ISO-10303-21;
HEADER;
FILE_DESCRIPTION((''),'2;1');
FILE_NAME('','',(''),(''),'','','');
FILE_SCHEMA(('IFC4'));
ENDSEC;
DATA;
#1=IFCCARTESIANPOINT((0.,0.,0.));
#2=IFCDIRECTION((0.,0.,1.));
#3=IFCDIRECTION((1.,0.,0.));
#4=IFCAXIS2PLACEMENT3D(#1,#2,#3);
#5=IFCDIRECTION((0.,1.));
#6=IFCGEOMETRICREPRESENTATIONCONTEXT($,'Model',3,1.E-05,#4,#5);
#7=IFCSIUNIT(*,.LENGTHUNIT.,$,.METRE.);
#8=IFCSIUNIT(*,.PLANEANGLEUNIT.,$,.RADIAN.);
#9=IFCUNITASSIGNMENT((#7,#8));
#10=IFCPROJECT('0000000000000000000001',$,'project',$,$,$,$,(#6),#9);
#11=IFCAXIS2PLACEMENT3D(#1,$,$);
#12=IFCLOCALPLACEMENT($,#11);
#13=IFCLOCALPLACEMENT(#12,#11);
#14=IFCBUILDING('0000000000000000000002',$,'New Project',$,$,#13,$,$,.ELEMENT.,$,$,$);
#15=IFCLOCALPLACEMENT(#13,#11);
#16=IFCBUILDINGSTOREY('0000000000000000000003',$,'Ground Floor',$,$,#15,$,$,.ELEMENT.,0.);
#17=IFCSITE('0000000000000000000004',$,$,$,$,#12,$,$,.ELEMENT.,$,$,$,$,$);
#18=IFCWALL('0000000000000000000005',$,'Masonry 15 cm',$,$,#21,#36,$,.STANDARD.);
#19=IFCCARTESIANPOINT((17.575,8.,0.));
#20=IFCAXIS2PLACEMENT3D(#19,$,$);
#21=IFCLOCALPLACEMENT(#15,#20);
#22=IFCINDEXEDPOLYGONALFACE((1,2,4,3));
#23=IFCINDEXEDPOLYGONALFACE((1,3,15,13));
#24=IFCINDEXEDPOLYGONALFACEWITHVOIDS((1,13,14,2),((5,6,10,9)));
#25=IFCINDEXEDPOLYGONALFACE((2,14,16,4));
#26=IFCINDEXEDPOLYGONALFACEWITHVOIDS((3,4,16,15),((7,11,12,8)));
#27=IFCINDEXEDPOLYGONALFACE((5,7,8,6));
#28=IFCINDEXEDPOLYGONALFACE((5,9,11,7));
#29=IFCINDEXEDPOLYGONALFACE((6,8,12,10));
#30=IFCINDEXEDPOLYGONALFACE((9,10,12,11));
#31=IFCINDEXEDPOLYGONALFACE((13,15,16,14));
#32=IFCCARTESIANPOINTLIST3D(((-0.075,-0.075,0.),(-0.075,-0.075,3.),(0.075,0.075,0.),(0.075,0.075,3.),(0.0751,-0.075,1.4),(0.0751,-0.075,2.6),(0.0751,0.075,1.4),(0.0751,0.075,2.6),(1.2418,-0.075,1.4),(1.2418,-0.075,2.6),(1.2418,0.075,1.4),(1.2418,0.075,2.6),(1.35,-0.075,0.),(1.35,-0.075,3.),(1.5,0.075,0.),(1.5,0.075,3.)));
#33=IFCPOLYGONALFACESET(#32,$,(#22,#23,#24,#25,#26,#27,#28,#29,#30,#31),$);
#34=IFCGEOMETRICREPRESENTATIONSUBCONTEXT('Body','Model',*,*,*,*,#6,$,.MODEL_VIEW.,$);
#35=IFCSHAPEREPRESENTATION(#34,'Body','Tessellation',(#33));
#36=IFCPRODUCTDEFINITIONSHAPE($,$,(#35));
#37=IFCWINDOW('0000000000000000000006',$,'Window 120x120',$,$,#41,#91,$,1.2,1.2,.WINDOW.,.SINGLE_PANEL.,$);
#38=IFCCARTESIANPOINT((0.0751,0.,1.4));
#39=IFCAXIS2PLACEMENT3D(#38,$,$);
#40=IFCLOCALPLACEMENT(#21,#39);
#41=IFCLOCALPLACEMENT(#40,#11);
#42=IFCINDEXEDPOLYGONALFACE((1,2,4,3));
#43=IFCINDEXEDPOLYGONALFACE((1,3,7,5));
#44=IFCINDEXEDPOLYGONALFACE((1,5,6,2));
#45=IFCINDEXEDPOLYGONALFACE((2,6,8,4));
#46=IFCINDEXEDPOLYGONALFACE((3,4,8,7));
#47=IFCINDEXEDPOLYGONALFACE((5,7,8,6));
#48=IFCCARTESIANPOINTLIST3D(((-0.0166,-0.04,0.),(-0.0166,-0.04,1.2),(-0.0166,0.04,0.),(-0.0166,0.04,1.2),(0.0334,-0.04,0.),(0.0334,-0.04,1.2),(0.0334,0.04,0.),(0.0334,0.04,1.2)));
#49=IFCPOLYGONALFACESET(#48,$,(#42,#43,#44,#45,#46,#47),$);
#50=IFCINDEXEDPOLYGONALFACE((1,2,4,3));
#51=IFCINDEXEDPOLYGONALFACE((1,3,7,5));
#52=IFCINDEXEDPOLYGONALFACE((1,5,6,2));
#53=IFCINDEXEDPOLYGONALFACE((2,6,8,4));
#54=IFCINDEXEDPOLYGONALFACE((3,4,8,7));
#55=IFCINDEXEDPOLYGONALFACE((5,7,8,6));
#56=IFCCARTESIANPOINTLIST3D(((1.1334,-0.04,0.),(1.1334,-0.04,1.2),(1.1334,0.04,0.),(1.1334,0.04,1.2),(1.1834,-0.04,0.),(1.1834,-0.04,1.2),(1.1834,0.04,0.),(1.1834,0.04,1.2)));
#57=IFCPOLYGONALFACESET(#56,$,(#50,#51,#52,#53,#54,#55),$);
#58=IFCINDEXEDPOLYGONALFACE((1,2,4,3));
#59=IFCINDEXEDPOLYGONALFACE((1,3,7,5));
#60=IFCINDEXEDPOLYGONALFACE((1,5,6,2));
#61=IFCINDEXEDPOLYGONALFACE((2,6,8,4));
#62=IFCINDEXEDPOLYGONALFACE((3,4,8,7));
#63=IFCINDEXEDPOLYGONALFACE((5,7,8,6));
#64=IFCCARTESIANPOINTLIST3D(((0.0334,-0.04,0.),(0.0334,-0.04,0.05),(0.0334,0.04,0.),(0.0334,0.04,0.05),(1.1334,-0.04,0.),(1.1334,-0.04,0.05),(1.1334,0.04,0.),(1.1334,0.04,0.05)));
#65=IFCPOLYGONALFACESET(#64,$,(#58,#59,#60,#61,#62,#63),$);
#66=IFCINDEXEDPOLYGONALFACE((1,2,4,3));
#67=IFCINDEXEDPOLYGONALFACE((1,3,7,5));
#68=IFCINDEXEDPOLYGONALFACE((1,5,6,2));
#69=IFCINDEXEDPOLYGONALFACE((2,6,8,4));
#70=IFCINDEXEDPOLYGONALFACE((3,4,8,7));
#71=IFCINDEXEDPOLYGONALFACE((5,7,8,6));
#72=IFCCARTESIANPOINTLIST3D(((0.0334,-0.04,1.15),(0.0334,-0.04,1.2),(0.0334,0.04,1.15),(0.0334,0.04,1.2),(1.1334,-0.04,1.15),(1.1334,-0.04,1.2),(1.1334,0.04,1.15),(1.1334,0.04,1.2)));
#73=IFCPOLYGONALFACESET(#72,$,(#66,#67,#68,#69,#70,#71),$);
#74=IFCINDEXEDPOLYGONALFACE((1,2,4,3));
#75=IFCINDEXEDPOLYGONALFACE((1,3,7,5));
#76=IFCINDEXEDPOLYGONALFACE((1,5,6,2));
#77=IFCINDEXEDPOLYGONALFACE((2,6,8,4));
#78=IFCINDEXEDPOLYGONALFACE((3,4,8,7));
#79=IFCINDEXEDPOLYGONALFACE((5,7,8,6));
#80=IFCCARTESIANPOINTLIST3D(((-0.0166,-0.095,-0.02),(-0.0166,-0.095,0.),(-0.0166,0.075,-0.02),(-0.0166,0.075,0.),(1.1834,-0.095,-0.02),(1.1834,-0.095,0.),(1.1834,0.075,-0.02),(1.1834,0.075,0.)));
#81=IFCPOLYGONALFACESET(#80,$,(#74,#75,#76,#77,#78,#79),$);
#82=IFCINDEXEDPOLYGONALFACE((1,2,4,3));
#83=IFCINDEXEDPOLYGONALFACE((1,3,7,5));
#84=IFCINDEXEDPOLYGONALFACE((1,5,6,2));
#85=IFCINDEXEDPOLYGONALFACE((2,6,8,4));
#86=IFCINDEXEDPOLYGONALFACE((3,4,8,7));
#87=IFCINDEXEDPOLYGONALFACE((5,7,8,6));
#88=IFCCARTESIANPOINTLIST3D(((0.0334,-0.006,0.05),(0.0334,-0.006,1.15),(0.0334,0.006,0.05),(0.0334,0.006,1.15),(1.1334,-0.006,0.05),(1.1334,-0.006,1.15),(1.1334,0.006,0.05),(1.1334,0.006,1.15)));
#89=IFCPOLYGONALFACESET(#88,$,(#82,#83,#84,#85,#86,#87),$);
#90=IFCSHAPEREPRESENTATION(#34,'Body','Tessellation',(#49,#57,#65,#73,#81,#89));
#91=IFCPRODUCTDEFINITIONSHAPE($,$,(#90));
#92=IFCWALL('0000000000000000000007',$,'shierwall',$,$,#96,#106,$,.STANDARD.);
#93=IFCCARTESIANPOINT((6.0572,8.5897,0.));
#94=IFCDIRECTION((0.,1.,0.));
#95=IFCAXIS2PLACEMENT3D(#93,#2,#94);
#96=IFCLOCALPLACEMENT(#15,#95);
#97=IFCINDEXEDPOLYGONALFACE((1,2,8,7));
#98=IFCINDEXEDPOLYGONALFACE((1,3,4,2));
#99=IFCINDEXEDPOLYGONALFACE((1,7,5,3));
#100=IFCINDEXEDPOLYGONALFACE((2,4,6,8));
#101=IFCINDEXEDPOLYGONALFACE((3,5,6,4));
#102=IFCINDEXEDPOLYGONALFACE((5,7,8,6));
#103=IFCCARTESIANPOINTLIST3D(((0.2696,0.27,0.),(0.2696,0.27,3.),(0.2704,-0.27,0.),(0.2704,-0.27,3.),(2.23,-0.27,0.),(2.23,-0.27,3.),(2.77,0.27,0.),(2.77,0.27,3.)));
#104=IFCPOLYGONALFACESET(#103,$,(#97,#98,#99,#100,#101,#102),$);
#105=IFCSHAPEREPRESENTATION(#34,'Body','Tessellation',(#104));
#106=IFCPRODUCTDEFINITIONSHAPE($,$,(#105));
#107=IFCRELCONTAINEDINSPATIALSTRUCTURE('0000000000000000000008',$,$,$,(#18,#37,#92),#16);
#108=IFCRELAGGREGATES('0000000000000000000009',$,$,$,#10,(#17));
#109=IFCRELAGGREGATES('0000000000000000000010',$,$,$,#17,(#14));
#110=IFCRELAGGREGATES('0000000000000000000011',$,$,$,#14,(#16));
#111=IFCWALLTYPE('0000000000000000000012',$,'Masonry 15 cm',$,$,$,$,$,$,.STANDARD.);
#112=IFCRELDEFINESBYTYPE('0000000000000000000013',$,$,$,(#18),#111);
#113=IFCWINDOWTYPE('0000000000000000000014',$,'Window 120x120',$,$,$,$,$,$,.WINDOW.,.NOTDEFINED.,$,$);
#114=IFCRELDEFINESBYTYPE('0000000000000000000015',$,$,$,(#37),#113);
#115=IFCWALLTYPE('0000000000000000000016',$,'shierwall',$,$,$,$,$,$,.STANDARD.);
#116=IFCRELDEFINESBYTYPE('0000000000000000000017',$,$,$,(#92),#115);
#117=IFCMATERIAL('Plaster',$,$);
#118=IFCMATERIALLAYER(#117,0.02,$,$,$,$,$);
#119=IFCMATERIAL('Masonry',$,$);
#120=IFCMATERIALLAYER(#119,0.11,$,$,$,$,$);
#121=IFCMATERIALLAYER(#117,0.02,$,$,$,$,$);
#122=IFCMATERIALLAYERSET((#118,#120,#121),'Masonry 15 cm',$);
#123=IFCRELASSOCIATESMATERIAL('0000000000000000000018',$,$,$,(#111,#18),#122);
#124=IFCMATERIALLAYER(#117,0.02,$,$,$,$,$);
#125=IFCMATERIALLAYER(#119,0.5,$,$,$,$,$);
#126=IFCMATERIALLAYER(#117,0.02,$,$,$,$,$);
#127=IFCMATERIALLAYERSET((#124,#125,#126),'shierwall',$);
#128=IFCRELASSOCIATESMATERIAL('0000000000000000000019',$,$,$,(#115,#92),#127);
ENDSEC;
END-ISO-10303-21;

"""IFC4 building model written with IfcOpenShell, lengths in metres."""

from ifc_helpers import new_model, si_unit, direction, frame, frame_2d, origin, origin_with_axes, place, context, subcontext, project, spatial, polyline, rectangle, outline, extrude, material, layer, layer_set, layer_usage, type_object, element, fill, save


model = new_model("IFC4")

# Units and contexts
model_context = context("Model", 3, precision=1e-05, world=origin_with_axes(), true_north=direction((0.0, 1.0)))
body_context = subcontext(model_context, "Body", "Model", "MODEL_VIEW")
ifc_project = project(units=[si_unit("LENGTHUNIT", "METRE"), si_unit("PLANEANGLEUNIT", "RADIAN")], contexts=[model_context])

# Site, building, storey
site_placement = place(None, origin())
site = spatial("IfcSite", under=ifc_project, at=site_placement, CompositionType="ELEMENT")
building_placement = place(site_placement, origin())
building = spatial("IfcBuilding", under=site, at=building_placement, Name="New Project", CompositionType="ELEMENT")
storey_placement = place(building_placement, origin())
storey = spatial("IfcBuildingStorey", under=building, at=storey_placement, Name="Ground Floor", CompositionType="ELEMENT", Elevation=0.0)

# Shared definitions
ifc_material_1 = material(Name="Plaster")
ifc_layer_1 = layer(ifc_material_1, 0.02)
ifc_material_2 = material(Name="Masonry")
ifc_layer_2 = layer(ifc_material_2, 0.11)
ifc_layer_3 = layer(ifc_material_1, 0.02)
ifc_layer_set_1 = layer_set([ifc_layer_1, ifc_layer_2, ifc_layer_3], Name="Masonry 15 cm")
ifc_layer_usage_1 = layer_usage(ifc_layer_set_1, "AXIS2", "NEGATIVE", 0.075)
wall_type_1 = type_object("IfcWallType", Name="Masonry 15 cm", PredefinedType="STANDARD", material=ifc_layer_set_1)

# Shared definitions
window_type = type_object("IfcWindowType", Name="Window 120x120", PartitioningType="NOTDEFINED", PredefinedType="WINDOW")

# Wall, opening, window
wall_1_placement = place(storey_placement, frame((17.575, 8.0, 0.0)))
wall_1 = element("IfcWall", 1, at=wall_1_placement, inside=storey, type_object=wall_type_1, material=ifc_layer_usage_1, Name="Masonry 15 cm", PredefinedType="STANDARD", context=body_context, shape_type="SweptSolid", body=[
    extrude(outline(polyline([(-0.075, -0.075), (1.35, -0.075), (1.5, 0.075), (0.075, 0.075), (-0.075, -0.075)])), origin(), (0.0, 0.0, 1.0), 3.0),
])
opening_1_placement = place(wall_1_placement, frame((0.0751, 0.0, 1.4)))
opening_1 = element("IfcOpeningElement", 2, at=opening_1_placement, cuts=wall_1, PredefinedType="OPENING", context=body_context, shape_type="SweptSolid", body=[
    extrude(rectangle(XDim=1.1667, YDim=0.25, at=frame_2d((0.5834, 0.0))), origin(), (0.0, 0.0, 1.0), 1.2),
])
window_1_placement = place(opening_1_placement, origin())
window_1 = element("IfcWindow", 3, at=window_1_placement, inside=storey, type_object=window_type, Name="Window 120x120", OverallHeight=1.2, OverallWidth=1.2, PartitioningType="SINGLE_PANEL", PredefinedType="WINDOW", context=body_context, shape_type="SweptSolid", body=[
    extrude(outline(polyline([(-0.0166, -0.04), (0.0334, -0.04), (0.0334, 0.04), (-0.0166, 0.04), (-0.0166, -0.04)])), origin(), (0.0, 0.0, 1.0), 1.2),
    extrude(outline(polyline([(1.1334, -0.04), (1.1834, -0.04), (1.1834, 0.04), (1.1334, 0.04), (1.1334, -0.04)])), origin(), (0.0, 0.0, 1.0), 1.2),
    extrude(outline(polyline([(0.0334, -0.04), (1.1334, -0.04), (1.1334, 0.04), (0.0334, 0.04), (0.0334, -0.04)])), origin(), (0.0, 0.0, 1.0), 0.05),
    extrude(outline(polyline([(0.0334, -0.04), (1.1334, -0.04), (1.1334, 0.04), (0.0334, 0.04), (0.0334, -0.04)])), frame((0.0, 0.0, 1.15)), (0.0, 0.0, 1.0), 0.05),
    extrude(outline(polyline([(-0.0166, -0.095), (1.1834, -0.095), (1.1834, 0.075), (-0.0166, 0.075), (-0.0166, -0.095)])), frame((0.0, 0.0, -0.02)), (0.0, 0.0, 1.0), 0.02),
    extrude(outline(polyline([(0.0334, -0.006), (1.1334, -0.006), (1.1334, 0.006), (0.0334, 0.006), (0.0334, -0.006)])), frame((0.0, 0.0, 0.05)), (0.0, 0.0, 1.0), 1.1),
])
fill(opening_1, window_1)

# Wall
ifc_layer_4 = layer(ifc_material_1, 0.02)
ifc_layer_5 = layer(ifc_material_2, 0.5)
ifc_layer_6 = layer(ifc_material_1, 0.02)
ifc_layer_set_2 = layer_set([ifc_layer_4, ifc_layer_5, ifc_layer_6], Name="shierwall")
ifc_layer_usage_2 = layer_usage(ifc_layer_set_2, "AXIS2", "NEGATIVE", 0.27)
wall_type_2 = type_object("IfcWallType", Name="shierwall", PredefinedType="STANDARD", material=ifc_layer_set_2)
wall_2_placement = place(storey_placement, frame((6.0572, 8.5897, 0.0), z_axis=(0.0, 0.0, 1.0), x_axis=(0.0, 1.0, 0.0)))
element("IfcWall", 4, at=wall_2_placement, inside=storey, type_object=wall_type_2, material=ifc_layer_usage_2, Name="shierwall", PredefinedType="STANDARD", context=body_context, shape_type="SweptSolid", body=[
    extrude(outline(polyline([(0.2704, -0.27), (2.23, -0.27), (2.77, 0.27), (0.2696, 0.27), (0.2704, -0.27)])), origin(), (0.0, 0.0, 1.0), 3.0),
])

save(model, "model.ifc")
